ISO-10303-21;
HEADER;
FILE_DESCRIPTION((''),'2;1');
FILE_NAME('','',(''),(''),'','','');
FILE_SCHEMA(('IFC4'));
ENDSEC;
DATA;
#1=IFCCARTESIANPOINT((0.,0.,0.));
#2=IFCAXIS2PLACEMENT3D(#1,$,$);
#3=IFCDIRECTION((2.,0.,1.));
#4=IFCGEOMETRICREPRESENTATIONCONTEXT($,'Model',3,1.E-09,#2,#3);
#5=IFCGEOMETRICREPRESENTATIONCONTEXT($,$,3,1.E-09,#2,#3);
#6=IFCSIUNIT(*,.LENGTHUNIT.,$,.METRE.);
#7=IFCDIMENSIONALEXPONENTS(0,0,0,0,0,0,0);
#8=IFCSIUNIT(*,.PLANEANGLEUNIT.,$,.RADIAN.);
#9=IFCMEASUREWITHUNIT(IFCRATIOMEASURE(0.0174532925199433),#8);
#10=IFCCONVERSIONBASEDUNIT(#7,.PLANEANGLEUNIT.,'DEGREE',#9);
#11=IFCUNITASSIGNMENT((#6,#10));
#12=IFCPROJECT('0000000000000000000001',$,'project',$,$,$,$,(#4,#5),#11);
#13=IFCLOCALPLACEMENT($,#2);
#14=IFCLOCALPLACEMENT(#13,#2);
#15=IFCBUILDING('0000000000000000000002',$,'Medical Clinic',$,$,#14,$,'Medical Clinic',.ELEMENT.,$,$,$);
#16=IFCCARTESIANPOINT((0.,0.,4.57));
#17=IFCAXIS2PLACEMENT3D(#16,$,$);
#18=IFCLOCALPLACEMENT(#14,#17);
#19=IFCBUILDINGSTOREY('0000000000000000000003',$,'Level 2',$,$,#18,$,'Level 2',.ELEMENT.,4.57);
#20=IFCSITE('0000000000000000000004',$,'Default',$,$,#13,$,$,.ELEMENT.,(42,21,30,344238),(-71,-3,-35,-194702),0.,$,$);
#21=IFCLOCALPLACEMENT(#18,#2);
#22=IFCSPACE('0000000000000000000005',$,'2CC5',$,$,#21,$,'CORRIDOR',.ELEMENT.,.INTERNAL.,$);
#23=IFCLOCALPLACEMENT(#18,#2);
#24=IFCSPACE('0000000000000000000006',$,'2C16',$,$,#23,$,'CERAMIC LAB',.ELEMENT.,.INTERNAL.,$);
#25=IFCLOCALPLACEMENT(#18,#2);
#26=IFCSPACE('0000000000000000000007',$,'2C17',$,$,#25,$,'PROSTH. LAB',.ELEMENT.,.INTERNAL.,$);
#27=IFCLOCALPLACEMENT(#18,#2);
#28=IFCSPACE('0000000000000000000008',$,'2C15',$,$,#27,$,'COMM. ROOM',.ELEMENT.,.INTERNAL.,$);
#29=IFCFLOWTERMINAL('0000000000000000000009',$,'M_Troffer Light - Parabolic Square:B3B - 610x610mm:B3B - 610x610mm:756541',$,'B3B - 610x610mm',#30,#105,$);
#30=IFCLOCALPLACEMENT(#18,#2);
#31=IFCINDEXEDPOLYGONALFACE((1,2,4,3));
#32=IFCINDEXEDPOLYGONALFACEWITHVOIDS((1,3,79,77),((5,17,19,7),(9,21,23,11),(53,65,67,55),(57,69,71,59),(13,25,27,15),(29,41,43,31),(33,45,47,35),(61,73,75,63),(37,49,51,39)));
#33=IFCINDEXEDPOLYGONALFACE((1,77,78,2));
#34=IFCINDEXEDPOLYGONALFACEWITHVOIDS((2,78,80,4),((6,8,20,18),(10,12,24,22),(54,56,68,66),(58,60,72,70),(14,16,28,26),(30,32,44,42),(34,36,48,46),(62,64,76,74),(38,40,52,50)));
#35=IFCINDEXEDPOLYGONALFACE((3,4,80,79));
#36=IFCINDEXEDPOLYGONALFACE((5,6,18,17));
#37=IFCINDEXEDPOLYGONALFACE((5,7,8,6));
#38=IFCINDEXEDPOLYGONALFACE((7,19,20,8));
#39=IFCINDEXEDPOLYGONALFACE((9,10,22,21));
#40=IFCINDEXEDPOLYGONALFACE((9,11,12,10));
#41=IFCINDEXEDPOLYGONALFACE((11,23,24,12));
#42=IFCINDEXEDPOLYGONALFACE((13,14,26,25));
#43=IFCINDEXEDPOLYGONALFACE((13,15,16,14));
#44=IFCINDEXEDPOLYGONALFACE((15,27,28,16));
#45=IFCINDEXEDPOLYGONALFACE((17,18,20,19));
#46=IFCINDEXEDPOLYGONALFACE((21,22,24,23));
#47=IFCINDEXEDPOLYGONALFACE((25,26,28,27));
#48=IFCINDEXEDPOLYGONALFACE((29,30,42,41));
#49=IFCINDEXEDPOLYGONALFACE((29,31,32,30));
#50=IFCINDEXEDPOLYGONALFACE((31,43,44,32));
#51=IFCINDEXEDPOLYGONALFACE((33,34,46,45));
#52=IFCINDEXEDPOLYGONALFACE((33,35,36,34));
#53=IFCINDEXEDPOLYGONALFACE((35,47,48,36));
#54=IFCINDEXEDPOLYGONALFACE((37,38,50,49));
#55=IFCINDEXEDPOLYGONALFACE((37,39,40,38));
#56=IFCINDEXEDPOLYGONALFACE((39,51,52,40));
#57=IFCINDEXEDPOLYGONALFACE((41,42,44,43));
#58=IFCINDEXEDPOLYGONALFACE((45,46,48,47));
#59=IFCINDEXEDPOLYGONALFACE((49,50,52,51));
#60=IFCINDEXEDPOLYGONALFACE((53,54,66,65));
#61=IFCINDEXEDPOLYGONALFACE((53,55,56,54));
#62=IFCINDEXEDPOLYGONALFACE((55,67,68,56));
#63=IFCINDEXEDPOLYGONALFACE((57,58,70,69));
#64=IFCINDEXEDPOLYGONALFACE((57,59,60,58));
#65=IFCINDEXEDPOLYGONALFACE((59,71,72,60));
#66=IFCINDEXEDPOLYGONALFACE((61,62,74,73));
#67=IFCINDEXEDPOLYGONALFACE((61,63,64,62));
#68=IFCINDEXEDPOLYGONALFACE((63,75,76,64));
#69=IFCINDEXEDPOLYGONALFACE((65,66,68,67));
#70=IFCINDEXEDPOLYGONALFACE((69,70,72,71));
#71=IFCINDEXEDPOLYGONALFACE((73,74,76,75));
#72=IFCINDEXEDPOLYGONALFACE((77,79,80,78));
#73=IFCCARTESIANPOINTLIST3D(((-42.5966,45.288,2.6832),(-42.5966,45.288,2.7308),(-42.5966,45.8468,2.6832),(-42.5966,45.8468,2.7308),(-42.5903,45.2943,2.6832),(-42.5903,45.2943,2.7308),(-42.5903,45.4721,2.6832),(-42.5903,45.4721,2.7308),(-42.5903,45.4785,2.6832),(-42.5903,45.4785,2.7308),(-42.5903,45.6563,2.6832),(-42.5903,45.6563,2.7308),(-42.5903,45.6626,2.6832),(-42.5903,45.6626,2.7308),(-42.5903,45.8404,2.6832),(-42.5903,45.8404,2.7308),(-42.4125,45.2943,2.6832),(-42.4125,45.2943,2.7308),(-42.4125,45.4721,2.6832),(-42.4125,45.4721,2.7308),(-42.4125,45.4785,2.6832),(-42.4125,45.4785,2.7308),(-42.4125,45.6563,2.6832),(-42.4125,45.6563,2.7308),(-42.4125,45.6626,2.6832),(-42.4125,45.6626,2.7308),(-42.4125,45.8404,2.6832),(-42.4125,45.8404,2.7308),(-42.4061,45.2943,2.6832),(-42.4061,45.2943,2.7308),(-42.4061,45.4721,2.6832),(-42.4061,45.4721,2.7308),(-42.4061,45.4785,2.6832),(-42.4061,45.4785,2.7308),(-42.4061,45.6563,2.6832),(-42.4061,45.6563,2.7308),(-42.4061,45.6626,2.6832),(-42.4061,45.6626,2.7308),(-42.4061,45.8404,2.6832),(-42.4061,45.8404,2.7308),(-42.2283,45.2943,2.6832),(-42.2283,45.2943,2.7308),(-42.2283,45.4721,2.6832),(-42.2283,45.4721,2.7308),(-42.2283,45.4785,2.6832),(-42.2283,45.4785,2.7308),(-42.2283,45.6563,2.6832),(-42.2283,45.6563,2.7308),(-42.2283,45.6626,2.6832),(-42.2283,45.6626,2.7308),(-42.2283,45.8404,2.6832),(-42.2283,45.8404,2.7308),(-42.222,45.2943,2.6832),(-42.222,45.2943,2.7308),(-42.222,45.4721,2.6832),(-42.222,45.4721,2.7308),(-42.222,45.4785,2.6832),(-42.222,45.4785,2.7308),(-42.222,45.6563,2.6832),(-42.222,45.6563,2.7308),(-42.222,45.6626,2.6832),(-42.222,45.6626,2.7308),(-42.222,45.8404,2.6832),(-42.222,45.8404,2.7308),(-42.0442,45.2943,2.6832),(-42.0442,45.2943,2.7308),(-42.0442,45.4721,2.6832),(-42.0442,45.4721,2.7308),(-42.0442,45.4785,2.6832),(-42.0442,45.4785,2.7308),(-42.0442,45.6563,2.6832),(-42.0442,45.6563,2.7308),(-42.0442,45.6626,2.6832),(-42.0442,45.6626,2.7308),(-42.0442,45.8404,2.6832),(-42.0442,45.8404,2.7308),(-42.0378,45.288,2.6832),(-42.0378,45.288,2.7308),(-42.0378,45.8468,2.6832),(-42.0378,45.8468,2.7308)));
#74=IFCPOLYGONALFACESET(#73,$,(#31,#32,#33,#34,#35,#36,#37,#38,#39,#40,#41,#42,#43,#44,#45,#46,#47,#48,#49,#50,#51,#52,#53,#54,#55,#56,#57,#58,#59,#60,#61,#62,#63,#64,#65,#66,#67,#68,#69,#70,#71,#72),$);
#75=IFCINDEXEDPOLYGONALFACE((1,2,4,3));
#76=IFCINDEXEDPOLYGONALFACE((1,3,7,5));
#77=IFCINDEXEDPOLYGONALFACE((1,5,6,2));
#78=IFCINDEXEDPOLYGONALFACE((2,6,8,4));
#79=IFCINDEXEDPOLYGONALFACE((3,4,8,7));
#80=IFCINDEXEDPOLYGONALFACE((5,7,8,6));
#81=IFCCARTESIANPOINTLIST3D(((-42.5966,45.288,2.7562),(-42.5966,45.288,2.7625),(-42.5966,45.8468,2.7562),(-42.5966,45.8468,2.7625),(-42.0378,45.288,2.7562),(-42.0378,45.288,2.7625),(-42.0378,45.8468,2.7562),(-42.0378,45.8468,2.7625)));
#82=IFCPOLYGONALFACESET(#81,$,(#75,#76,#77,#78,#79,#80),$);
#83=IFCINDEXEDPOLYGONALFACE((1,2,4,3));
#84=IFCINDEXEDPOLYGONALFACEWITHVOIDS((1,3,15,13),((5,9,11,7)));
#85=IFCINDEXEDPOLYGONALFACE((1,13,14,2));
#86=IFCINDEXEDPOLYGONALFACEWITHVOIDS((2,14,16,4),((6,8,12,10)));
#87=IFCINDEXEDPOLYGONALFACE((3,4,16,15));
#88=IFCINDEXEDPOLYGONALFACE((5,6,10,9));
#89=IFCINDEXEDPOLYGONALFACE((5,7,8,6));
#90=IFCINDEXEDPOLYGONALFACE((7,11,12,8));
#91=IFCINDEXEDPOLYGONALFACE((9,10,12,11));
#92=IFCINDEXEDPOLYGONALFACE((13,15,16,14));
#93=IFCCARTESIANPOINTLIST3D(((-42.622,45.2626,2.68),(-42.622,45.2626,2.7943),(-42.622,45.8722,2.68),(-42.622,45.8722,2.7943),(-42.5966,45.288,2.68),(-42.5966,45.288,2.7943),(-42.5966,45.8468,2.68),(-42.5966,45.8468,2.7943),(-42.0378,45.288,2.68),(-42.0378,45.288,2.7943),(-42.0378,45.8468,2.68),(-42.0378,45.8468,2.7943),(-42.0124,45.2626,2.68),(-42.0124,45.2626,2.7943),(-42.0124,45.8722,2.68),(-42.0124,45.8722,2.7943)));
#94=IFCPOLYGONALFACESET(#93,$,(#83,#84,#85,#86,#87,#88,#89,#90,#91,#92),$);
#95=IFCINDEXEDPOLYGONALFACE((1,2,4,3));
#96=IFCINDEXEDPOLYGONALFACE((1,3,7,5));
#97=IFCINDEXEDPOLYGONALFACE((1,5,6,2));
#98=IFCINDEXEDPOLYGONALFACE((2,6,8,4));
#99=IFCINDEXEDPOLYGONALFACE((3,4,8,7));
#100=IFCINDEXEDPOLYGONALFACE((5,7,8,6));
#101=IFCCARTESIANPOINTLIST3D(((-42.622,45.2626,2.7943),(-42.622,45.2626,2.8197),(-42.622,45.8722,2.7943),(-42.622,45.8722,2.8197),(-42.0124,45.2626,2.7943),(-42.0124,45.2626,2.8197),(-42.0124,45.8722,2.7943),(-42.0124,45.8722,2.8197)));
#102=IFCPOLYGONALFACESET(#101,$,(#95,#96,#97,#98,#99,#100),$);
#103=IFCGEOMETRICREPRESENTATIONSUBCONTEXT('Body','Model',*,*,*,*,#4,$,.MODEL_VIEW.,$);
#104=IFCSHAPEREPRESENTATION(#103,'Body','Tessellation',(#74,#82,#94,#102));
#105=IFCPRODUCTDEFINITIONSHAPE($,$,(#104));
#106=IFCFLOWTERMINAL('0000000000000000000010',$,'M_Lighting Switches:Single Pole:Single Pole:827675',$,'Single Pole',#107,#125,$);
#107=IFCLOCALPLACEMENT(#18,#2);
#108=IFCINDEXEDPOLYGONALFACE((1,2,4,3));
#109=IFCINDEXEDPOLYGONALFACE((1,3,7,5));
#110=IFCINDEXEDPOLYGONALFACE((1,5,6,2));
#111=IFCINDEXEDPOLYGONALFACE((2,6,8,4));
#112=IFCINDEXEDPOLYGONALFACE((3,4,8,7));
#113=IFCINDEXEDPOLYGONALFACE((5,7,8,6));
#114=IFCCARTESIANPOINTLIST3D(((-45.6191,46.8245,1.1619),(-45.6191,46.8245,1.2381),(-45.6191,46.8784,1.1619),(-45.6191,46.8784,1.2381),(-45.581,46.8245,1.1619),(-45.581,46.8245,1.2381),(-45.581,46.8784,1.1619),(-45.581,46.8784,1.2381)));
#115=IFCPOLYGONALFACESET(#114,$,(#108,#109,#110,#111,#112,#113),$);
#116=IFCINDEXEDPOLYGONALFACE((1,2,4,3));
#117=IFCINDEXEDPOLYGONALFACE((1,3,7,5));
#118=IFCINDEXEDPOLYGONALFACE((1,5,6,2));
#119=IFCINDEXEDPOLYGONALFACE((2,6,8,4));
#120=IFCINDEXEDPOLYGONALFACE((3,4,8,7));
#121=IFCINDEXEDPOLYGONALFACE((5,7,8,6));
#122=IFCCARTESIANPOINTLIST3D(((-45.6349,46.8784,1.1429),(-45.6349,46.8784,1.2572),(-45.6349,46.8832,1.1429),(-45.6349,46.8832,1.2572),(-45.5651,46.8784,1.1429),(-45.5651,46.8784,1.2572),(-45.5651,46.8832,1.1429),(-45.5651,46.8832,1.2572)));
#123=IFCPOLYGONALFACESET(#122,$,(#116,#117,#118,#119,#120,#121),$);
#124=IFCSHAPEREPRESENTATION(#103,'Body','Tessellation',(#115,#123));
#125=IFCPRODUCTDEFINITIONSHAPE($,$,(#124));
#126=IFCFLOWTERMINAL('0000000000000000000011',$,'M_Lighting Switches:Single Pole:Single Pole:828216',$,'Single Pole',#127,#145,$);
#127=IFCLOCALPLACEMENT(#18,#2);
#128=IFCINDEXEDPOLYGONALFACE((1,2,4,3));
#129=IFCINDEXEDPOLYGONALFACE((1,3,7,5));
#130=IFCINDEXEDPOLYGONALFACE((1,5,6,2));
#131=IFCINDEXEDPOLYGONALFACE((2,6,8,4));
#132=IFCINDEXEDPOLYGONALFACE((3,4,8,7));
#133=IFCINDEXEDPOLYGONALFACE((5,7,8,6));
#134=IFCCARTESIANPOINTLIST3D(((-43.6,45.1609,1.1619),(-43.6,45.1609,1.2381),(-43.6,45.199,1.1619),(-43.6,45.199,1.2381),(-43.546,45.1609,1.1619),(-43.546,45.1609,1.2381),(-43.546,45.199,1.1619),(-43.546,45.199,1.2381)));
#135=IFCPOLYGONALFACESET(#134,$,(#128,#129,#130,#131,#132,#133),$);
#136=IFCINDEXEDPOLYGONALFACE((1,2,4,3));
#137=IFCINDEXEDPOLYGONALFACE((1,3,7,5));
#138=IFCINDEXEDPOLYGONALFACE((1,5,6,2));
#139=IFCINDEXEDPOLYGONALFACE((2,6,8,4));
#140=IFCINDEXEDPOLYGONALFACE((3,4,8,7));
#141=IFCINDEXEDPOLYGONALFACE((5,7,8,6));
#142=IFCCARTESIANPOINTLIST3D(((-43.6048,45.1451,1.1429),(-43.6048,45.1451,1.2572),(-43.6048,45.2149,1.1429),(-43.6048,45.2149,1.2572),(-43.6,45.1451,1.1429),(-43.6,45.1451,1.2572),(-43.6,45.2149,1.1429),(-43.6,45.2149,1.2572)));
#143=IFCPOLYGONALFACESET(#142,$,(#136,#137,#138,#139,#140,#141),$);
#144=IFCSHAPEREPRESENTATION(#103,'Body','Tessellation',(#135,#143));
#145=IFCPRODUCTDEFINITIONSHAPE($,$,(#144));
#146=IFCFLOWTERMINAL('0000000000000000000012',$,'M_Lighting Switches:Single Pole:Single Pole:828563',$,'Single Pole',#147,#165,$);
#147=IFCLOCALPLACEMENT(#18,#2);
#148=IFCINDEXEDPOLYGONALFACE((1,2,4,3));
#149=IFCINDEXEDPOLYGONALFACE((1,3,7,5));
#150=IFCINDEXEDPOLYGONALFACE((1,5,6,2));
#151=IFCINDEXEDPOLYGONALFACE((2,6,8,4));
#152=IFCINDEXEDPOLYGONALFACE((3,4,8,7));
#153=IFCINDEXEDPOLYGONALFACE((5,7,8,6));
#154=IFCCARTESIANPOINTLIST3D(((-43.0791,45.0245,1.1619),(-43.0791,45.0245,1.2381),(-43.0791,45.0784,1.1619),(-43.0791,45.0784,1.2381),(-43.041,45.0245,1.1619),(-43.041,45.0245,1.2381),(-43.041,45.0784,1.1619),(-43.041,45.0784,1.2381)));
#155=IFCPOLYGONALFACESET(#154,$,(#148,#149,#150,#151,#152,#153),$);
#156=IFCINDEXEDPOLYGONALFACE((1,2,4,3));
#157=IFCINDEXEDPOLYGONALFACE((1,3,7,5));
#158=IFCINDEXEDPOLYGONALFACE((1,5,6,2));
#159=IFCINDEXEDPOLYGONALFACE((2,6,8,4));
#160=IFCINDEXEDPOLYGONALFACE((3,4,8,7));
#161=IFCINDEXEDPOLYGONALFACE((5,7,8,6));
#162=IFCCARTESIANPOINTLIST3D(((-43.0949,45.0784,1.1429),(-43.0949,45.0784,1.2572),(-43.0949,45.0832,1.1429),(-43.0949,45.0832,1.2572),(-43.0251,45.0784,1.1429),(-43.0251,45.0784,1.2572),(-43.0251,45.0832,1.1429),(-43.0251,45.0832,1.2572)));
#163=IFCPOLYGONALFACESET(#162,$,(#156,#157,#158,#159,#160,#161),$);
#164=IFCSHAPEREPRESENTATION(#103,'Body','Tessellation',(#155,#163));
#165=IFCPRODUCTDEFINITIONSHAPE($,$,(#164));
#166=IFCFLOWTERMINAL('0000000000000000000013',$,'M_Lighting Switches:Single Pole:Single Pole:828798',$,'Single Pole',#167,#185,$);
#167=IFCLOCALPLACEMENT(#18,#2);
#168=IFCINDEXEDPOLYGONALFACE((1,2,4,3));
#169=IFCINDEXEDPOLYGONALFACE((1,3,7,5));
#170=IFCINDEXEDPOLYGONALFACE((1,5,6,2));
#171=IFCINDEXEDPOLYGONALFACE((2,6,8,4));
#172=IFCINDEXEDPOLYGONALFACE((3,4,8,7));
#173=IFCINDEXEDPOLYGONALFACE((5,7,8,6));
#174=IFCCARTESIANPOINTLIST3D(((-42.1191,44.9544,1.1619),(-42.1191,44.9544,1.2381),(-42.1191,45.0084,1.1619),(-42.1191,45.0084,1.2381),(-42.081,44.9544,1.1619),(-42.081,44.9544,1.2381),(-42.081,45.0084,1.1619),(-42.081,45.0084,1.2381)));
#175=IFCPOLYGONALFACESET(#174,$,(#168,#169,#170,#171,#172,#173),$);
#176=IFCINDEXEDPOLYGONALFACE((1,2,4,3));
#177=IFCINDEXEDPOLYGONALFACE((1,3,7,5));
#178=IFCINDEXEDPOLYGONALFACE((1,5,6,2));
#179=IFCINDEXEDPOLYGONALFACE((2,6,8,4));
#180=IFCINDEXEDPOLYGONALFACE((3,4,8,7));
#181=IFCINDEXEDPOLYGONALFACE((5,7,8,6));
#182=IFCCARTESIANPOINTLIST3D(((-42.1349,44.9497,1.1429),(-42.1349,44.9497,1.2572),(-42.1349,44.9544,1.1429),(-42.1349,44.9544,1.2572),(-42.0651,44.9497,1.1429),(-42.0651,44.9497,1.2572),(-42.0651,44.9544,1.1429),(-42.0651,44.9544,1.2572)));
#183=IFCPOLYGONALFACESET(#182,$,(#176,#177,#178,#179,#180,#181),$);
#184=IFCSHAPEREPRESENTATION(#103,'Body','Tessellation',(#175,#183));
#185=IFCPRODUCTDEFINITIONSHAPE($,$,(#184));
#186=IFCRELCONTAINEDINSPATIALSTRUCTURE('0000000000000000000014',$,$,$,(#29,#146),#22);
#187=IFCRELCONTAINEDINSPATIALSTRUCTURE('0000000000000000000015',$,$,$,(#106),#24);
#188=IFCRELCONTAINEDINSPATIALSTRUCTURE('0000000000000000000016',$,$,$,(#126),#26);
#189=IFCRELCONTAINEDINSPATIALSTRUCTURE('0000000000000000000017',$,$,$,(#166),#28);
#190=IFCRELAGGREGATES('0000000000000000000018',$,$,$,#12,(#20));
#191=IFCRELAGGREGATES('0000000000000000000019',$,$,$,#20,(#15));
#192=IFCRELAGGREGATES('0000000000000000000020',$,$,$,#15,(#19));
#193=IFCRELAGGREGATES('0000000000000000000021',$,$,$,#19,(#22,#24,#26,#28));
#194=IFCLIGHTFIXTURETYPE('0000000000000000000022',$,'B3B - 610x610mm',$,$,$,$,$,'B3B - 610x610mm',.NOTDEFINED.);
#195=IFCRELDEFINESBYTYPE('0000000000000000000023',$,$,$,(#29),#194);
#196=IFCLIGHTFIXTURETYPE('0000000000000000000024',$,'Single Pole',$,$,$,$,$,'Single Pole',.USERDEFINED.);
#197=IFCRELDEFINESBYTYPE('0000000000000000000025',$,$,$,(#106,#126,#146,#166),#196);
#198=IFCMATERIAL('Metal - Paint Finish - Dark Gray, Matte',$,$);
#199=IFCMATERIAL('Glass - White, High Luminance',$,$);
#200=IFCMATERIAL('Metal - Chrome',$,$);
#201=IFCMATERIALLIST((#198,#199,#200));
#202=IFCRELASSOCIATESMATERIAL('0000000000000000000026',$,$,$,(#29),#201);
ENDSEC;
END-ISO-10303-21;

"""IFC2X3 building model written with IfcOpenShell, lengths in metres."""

from ifc_helpers import new_model, entity, si_unit, converted_unit, direction, frame, frame_2d, origin, origin_2d_with_axis, place, context, subcontext, project, spatial, polyline, rectangle, outline, extrude, source, transform, mapped, material, material_list, type_object, type_shapes, element, save


model = new_model("IFC2X3")

# Units and contexts
model_context = context("Model", 3, precision=1e-09, world=origin(), true_north=direction((2.0, 0.0, 1.0)))
context_of_model = context(None, 3, precision=1e-09, world=origin(), true_north=direction((2.0, 0.0, 1.0)))
body_context = subcontext(model_context, "Body", "Model", "MODEL_VIEW")
ifc_project = project(units=[si_unit("LENGTHUNIT", "METRE"), converted_unit("PLANEANGLEUNIT", "DEGREE", entity("IfcRatioMeasure", 0.0174532925199433), si_unit("PLANEANGLEUNIT", "RADIAN"), dimensions=[0, 0, 0, 0, 0, 0, 0])], contexts=[model_context, context_of_model])

# Site, building, storey, space
site_placement = place(None, origin())
site = spatial("IfcSite", under=ifc_project, at=site_placement, Name="Default", CompositionType="ELEMENT", RefLatitude=(42, 21, 30, 344238), RefLongitude=(-71, -3, -35, -194702), RefElevation=0.0)
building_placement = place(site_placement, origin())
building = spatial("IfcBuilding", under=site, at=building_placement, Name="Medical Clinic", LongName="Medical Clinic", CompositionType="ELEMENT")
storey_placement = place(building_placement, frame((0.0, 0.0, 4.57)))
storey = spatial("IfcBuildingStorey", under=building, at=storey_placement, Name="Level 2", LongName="Level 2", CompositionType="ELEMENT", Elevation=4.57)
space_1_placement = place(storey_placement, origin())
space_1 = spatial("IfcSpace", under=storey, at=space_1_placement, Name="2CC5", LongName="CORRIDOR", CompositionType="ELEMENT", InteriorOrExteriorSpace="INTERNAL")

# Flow terminal
ifc_material_1 = material(Name="Metal - Paint Finish - Dark Gray, Matte")
ifc_material_2 = material(Name="Glass - White, High Luminance")
ifc_material_3 = material(Name="Metal - Chrome")
ifc_material_list = material_list([ifc_material_1, ifc_material_2, ifc_material_3])
light_fixture_type_1 = type_object("IfcLightFixtureType", Name="B3B - 610x610mm", ElementType="B3B - 610x610mm", PredefinedType="NOTDEFINED")
shared_shape_1 = source(origin(), body_context, "Body", "SweptSolid", [
    extrude(outline(polyline([(-0.2794, -0.2794), (0.2794, -0.2794), (0.2794, 0.2794), (-0.2794, 0.2794), (-0.2794, -0.2794)]), holes=[polyline([(-0.0952, 0.0953), (-0.273, 0.0953), (-0.273, 0.2731), (-0.0952, 0.2731), (-0.0952, 0.0953)]), polyline([(0.2731, 0.0953), (0.0953, 0.0953), (0.0953, 0.2731), (0.2731, 0.2731), (0.2731, 0.0953)]), polyline([(-0.0889, 0.2731), (0.0889, 0.2731), (0.0889, 0.0953), (-0.0889, 0.0953), (-0.0889, 0.2731)]), polyline([(0.2731, -0.273), (0.0953, -0.273), (0.0953, -0.0952), (0.2731, -0.0952), (0.2731, -0.273)]), polyline([(0.0889, -0.273), (-0.0889, -0.273), (-0.0889, -0.0952), (0.0889, -0.0952), (0.0889, -0.273)]), polyline([(-0.0952, -0.273), (-0.273, -0.273), (-0.273, -0.0952), (-0.0952, -0.0952), (-0.0952, -0.273)]), polyline([(-0.0952, -0.0889), (-0.273, -0.0889), (-0.273, 0.0889), (-0.0952, 0.0889), (-0.0952, -0.0889)]), polyline([(0.0889, -0.0889), (-0.0889, -0.0889), (-0.0889, 0.0889), (0.0889, 0.0889), (0.0889, -0.0889)]), polyline([(0.2731, -0.0889), (0.0953, -0.0889), (0.0953, 0.0889), (0.2731, 0.0889), (0.2731, -0.0889)])]), frame((0.0, -0.3048, -0.0508), z_axis=(0.0, 0.0, 1.0), x_axis=(-1.0, 0.0, 0.0)), (0.0, 0.0, 1.0), 0.0476),
    extrude(rectangle(XDim=0.5588, YDim=0.5588, at=origin_2d_with_axis()), frame((0.0, -0.3048, -0.0825), z_axis=(0.0, 0.0, 1.0), x_axis=(-1.0, 0.0, 0.0)), (0.0, 0.0, 1.0), 0.0064),
    extrude(outline(polyline([(-0.3048, -0.3048), (0.3048, -0.3048), (0.3048, 0.3048), (-0.3048, 0.3048), (-0.3048, -0.3048)]), holes=[polyline([(0.2794, 0.2794), (0.2794, -0.2794), (-0.2794, -0.2794), (-0.2794, 0.2794), (0.2794, 0.2794)])]), frame((0.0, -0.3048, -0.1143)), (0.0, 0.0, 1.0), 0.1143),
    extrude(rectangle(XDim=0.6096, YDim=0.6096, at=origin_2d_with_axis()), frame((0.0, -0.3048, -0.1397), z_axis=(0.0, 0.0, 1.0), x_axis=(-1.0, 0.0, 0.0)), (0.0, 0.0, 1.0), 0.0254),
])
type_shapes(light_fixture_type_1, [shared_shape_1])
flow_terminal_1_placement = place(space_1_placement, frame((-42.3172, 45.2626, 2.68), z_axis=(0.0, 0.0, -1.0), x_axis=(1.0, 0.0, 0.0)))
element("IfcFlowTerminal", 1, at=flow_terminal_1_placement, inside=space_1, type_object=light_fixture_type_1, material=ifc_material_list, Name="M_Troffer Light - Parabolic Square:B3B - 610x610mm:B3B - 610x610mm:756541", ObjectType="B3B - 610x610mm", context=body_context, shape_type="MappedRepresentation", body=[
    mapped(shared_shape_1, transform((0.0, 0.0, 0.0), scale=1.0)),
])

# Shared definitions
space_2_placement = place(storey_placement, origin())
space_2 = spatial("IfcSpace", under=storey, at=space_2_placement, Name="2C16", LongName="CERAMIC LAB", CompositionType="ELEMENT", InteriorOrExteriorSpace="INTERNAL")

# Flow terminal
light_fixture_type_2 = type_object("IfcLightFixtureType", Name="Single Pole", ElementType="Single Pole", PredefinedType="USERDEFINED")
shared_shape_2 = source(origin(), body_context, "Body", "SweptSolid", [
    extrude(rectangle(XDim=0.0381, YDim=0.0762, at=origin_2d_with_axis()), frame((0.0, 0.0, -0.054), z_axis=(0.0, 0.0, 1.0), x_axis=(-1.0, 0.0, 0.0)), (0.0, 0.0, 1.0), 0.054),
    extrude(rectangle(XDim=0.0698, YDim=0.1143, at=frame_2d((0.0, 0.0), x_axis=(1.0, 0.0))), frame((0.0, 0.0, 0.0), z_axis=(0.0, 0.0, 1.0), x_axis=(-1.0, 0.0, 0.0)), (0.0, 0.0, 1.0), 0.0048),
])
type_shapes(light_fixture_type_2, [shared_shape_2])
flow_terminal_2_placement = place(space_2_placement, frame((-45.6, 46.8784, 1.2), z_axis=(0.0, 1.0, 0.0), x_axis=(-1.0, 0.0, 0.0)))
element("IfcFlowTerminal", 2, at=flow_terminal_2_placement, inside=space_2, type_object=light_fixture_type_2, Name="M_Lighting Switches:Single Pole:Single Pole:827675", ObjectType="Single Pole", context=body_context, shape_type="MappedRepresentation", body=[
    mapped(shared_shape_2, transform((0.0, 0.0, 0.0), scale=1.0)),
])

# Shared definitions
space_3_placement = place(storey_placement, origin())
space_3 = spatial("IfcSpace", under=storey, at=space_3_placement, Name="2C17", LongName="PROSTH. LAB", CompositionType="ELEMENT", InteriorOrExteriorSpace="INTERNAL")

# Flow terminals
flow_terminal_3_placement = place(space_3_placement, frame((-43.6, 45.18, 1.2), z_axis=(-1.0, 0.0, 0.0), x_axis=(0.0, -1.0, 0.0)))
element("IfcFlowTerminal", 3, at=flow_terminal_3_placement, inside=space_3, type_object=light_fixture_type_2, Name="M_Lighting Switches:Single Pole:Single Pole:828216", ObjectType="Single Pole", context=body_context, shape_type="MappedRepresentation", body=[
    mapped(shared_shape_2, transform((0.0, 0.0, 0.0), scale=1.0)),
])
flow_terminal_4_placement = place(space_1_placement, frame((-43.06, 45.0784, 1.2), z_axis=(0.0, 1.0, 0.0), x_axis=(-1.0, 0.0, 0.0)))
element("IfcFlowTerminal", 4, at=flow_terminal_4_placement, inside=space_1, type_object=light_fixture_type_2, Name="M_Lighting Switches:Single Pole:Single Pole:828563", ObjectType="Single Pole", context=body_context, shape_type="MappedRepresentation", body=[
    mapped(shared_shape_2, transform((0.0, 0.0, 0.0), scale=1.0)),
])

# Shared definitions
space_4_placement = place(storey_placement, origin())
space_4 = spatial("IfcSpace", under=storey, at=space_4_placement, Name="2C15", LongName="COMM. ROOM", CompositionType="ELEMENT", InteriorOrExteriorSpace="INTERNAL")

# Flow terminal
flow_terminal_5_placement = place(space_4_placement, frame((-42.1, 44.9544, 1.2), z_axis=(0.0, -1.0, 0.0), x_axis=(1.0, 0.0, 0.0)))
element("IfcFlowTerminal", 5, at=flow_terminal_5_placement, inside=space_4, type_object=light_fixture_type_2, Name="M_Lighting Switches:Single Pole:Single Pole:828798", ObjectType="Single Pole", context=body_context, shape_type="MappedRepresentation", body=[
    mapped(shared_shape_2, transform((0.0, 0.0, 0.0), scale=1.0)),
])

save(model, "model.ifc")
